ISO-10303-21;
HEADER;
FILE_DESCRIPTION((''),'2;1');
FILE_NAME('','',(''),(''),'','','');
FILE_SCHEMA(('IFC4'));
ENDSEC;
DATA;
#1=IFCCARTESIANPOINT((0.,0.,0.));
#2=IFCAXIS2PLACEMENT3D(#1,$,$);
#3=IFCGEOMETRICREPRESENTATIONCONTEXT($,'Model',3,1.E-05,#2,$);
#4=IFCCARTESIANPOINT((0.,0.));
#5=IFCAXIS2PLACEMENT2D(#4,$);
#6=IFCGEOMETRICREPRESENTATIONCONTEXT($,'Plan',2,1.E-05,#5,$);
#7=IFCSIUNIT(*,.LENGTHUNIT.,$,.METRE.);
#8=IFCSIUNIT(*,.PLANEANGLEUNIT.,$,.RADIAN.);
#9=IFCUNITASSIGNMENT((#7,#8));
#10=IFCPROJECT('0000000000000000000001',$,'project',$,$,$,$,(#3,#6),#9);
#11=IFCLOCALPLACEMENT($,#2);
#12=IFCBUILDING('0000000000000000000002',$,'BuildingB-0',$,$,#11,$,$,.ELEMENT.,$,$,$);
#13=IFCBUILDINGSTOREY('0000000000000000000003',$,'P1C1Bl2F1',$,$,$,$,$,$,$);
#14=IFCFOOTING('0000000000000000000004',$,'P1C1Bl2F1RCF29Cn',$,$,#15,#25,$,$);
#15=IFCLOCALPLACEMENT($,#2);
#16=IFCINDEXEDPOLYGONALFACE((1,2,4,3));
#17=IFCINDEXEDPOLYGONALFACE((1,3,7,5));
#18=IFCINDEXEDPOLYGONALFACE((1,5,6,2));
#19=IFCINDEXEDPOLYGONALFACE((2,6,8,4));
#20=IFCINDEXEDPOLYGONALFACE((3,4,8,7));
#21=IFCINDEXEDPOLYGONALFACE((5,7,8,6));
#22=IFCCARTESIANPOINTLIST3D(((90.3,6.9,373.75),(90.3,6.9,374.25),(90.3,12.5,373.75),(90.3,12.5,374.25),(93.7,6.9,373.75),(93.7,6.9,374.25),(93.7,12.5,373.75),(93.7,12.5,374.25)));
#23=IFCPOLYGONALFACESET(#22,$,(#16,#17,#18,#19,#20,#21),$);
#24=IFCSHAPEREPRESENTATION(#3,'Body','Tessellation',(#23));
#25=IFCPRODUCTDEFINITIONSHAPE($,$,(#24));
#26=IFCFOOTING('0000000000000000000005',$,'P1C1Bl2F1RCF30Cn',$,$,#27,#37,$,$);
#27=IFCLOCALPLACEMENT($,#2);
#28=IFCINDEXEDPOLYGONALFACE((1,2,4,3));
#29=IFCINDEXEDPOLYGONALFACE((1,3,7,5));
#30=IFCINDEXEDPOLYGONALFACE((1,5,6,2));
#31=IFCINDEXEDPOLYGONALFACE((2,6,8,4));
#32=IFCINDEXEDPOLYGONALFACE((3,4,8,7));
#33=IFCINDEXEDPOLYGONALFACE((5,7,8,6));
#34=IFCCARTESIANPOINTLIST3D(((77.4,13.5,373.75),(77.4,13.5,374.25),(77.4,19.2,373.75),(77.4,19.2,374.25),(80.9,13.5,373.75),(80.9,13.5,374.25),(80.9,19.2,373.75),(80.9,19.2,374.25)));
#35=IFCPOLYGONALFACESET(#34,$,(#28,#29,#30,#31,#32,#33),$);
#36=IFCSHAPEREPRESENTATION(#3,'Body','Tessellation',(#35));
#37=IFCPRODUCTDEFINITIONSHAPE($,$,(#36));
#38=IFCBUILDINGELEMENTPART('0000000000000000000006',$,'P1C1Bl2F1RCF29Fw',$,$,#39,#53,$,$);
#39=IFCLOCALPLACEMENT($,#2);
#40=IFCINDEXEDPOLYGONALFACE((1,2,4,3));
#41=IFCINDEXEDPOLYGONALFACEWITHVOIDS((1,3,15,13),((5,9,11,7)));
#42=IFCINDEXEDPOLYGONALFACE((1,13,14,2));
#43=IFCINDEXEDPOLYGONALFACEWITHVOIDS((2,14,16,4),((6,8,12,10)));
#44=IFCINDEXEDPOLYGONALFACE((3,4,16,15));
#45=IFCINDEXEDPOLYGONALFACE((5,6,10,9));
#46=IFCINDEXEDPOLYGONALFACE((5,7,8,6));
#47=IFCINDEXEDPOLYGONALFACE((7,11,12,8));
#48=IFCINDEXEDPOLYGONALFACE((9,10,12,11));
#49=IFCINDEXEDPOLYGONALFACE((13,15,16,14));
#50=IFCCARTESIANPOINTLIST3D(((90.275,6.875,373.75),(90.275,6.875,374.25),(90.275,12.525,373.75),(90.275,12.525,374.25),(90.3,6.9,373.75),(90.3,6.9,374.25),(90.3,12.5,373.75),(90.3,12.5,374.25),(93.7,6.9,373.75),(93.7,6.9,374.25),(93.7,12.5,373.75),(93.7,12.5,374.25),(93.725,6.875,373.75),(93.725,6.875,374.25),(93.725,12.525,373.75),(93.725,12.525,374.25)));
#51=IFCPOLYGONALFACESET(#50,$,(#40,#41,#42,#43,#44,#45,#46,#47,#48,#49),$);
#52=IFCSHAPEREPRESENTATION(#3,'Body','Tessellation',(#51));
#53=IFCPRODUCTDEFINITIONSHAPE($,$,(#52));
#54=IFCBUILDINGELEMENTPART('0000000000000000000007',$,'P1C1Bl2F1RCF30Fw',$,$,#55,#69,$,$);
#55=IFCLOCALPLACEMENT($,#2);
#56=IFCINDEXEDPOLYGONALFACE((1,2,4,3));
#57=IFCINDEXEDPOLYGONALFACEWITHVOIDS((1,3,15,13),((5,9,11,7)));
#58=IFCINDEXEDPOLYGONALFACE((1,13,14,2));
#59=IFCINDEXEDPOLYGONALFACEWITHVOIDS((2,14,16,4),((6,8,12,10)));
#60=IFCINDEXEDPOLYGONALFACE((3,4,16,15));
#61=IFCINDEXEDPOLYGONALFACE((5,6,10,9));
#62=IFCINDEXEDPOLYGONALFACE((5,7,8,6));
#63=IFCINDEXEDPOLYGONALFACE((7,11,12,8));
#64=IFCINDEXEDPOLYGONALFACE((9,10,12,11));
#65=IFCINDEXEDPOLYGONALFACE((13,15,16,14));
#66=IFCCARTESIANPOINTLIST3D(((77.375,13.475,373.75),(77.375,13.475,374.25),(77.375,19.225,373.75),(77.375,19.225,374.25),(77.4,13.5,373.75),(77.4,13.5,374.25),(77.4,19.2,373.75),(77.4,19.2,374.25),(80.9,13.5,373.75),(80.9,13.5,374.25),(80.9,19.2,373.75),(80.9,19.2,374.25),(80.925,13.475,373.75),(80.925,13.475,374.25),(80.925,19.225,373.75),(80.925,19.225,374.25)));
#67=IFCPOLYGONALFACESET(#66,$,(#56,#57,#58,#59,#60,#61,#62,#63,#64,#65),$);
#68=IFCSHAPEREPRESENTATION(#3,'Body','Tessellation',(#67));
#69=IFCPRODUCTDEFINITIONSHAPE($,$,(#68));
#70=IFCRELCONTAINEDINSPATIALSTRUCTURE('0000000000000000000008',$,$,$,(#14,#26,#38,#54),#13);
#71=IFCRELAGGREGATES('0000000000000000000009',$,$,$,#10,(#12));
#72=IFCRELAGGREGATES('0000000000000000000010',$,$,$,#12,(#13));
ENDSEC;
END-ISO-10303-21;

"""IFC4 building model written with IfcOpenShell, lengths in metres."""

from ifc_helpers import new_model, si_unit, origin, origin_2d, place, context, project, spatial, polyline, outline, extrude, element, save


model = new_model("IFC4")

# Units and contexts
model_context = context("Model", 3, precision=1e-05, world=origin())
plan_context = context("Plan", 2, precision=1e-05, world=origin_2d())
ifc_project = project(units=[si_unit("LENGTHUNIT", "METRE"), si_unit("PLANEANGLEUNIT", "RADIAN")], contexts=[model_context, plan_context])

# Building, storey
building_placement = place(None, origin())
building = spatial("IfcBuilding", under=ifc_project, at=building_placement, Name="BuildingB-0", CompositionType="ELEMENT")
storey = spatial("IfcBuildingStorey", under=building, Name="P1C1Bl2F1")

# Footings
element("IfcFooting", 1, inside=storey, Name="P1C1Bl2F1RCF29Cn", context=model_context, shape_type="SweptSolid", body=[
    extrude(outline(polyline([(90.3, 12.5, 373.75), (93.7, 12.5, 373.75), (93.7, 6.9, 373.75), (90.3, 6.9, 373.75), (90.3, 12.5, 373.75)])), None, (0.0, 0.0, 1.0), 0.5),
])
element("IfcFooting", 2, inside=storey, Name="P1C1Bl2F1RCF30Cn", context=model_context, shape_type="SweptSolid", body=[
    extrude(outline(polyline([(77.4, 19.2, 373.75), (80.9, 19.2, 373.75), (80.9, 13.5, 373.75), (77.4, 13.5, 373.75), (77.4, 19.2, 373.75)])), None, (0.0, 0.0, 1.0), 0.5),
])

# Building element part, opening
building_element_part_1 = element("IfcBuildingElementPart", 3, inside=storey, Name="P1C1Bl2F1RCF29Fw", context=model_context, shape_type="SweptSolid", body=[
    extrude(outline(polyline([(90.275, 12.525, 373.75), (93.725, 12.525, 373.75), (93.725, 6.875, 373.75), (90.275, 6.875, 373.75), (90.275, 12.525, 373.75)])), None, (0.0, 0.0, 1.0), 0.5),
])
element("IfcOpeningElement", 4, inside=storey, cuts=building_element_part_1, context=model_context, shape_type="SweptSolid", body=[
    extrude(outline(polyline([(90.3, 12.5, 373.75), (93.7, 12.5, 373.75), (93.7, 6.9, 373.75), (90.3, 6.9, 373.75), (90.3, 12.5, 373.75)])), None, (0.0, 0.0, 1.0), 0.5),
])

# Building element part, opening
building_element_part_2 = element("IfcBuildingElementPart", 5, inside=storey, Name="P1C1Bl2F1RCF30Fw", context=model_context, shape_type="SweptSolid", body=[
    extrude(outline(polyline([(77.375, 19.225, 373.75), (80.925, 19.225, 373.75), (80.925, 13.475, 373.75), (77.375, 13.475, 373.75), (77.375, 19.225, 373.75)])), None, (0.0, 0.0, 1.0), 0.5),
])
element("IfcOpeningElement", 6, inside=storey, cuts=building_element_part_2, context=model_context, shape_type="SweptSolid", body=[
    extrude(outline(polyline([(77.4, 19.2, 373.75), (80.9, 19.2, 373.75), (80.9, 13.5, 373.75), (77.4, 13.5, 373.75), (77.4, 19.2, 373.75)])), None, (0.0, 0.0, 1.0), 0.5),
])

save(model, "model.ifc")
